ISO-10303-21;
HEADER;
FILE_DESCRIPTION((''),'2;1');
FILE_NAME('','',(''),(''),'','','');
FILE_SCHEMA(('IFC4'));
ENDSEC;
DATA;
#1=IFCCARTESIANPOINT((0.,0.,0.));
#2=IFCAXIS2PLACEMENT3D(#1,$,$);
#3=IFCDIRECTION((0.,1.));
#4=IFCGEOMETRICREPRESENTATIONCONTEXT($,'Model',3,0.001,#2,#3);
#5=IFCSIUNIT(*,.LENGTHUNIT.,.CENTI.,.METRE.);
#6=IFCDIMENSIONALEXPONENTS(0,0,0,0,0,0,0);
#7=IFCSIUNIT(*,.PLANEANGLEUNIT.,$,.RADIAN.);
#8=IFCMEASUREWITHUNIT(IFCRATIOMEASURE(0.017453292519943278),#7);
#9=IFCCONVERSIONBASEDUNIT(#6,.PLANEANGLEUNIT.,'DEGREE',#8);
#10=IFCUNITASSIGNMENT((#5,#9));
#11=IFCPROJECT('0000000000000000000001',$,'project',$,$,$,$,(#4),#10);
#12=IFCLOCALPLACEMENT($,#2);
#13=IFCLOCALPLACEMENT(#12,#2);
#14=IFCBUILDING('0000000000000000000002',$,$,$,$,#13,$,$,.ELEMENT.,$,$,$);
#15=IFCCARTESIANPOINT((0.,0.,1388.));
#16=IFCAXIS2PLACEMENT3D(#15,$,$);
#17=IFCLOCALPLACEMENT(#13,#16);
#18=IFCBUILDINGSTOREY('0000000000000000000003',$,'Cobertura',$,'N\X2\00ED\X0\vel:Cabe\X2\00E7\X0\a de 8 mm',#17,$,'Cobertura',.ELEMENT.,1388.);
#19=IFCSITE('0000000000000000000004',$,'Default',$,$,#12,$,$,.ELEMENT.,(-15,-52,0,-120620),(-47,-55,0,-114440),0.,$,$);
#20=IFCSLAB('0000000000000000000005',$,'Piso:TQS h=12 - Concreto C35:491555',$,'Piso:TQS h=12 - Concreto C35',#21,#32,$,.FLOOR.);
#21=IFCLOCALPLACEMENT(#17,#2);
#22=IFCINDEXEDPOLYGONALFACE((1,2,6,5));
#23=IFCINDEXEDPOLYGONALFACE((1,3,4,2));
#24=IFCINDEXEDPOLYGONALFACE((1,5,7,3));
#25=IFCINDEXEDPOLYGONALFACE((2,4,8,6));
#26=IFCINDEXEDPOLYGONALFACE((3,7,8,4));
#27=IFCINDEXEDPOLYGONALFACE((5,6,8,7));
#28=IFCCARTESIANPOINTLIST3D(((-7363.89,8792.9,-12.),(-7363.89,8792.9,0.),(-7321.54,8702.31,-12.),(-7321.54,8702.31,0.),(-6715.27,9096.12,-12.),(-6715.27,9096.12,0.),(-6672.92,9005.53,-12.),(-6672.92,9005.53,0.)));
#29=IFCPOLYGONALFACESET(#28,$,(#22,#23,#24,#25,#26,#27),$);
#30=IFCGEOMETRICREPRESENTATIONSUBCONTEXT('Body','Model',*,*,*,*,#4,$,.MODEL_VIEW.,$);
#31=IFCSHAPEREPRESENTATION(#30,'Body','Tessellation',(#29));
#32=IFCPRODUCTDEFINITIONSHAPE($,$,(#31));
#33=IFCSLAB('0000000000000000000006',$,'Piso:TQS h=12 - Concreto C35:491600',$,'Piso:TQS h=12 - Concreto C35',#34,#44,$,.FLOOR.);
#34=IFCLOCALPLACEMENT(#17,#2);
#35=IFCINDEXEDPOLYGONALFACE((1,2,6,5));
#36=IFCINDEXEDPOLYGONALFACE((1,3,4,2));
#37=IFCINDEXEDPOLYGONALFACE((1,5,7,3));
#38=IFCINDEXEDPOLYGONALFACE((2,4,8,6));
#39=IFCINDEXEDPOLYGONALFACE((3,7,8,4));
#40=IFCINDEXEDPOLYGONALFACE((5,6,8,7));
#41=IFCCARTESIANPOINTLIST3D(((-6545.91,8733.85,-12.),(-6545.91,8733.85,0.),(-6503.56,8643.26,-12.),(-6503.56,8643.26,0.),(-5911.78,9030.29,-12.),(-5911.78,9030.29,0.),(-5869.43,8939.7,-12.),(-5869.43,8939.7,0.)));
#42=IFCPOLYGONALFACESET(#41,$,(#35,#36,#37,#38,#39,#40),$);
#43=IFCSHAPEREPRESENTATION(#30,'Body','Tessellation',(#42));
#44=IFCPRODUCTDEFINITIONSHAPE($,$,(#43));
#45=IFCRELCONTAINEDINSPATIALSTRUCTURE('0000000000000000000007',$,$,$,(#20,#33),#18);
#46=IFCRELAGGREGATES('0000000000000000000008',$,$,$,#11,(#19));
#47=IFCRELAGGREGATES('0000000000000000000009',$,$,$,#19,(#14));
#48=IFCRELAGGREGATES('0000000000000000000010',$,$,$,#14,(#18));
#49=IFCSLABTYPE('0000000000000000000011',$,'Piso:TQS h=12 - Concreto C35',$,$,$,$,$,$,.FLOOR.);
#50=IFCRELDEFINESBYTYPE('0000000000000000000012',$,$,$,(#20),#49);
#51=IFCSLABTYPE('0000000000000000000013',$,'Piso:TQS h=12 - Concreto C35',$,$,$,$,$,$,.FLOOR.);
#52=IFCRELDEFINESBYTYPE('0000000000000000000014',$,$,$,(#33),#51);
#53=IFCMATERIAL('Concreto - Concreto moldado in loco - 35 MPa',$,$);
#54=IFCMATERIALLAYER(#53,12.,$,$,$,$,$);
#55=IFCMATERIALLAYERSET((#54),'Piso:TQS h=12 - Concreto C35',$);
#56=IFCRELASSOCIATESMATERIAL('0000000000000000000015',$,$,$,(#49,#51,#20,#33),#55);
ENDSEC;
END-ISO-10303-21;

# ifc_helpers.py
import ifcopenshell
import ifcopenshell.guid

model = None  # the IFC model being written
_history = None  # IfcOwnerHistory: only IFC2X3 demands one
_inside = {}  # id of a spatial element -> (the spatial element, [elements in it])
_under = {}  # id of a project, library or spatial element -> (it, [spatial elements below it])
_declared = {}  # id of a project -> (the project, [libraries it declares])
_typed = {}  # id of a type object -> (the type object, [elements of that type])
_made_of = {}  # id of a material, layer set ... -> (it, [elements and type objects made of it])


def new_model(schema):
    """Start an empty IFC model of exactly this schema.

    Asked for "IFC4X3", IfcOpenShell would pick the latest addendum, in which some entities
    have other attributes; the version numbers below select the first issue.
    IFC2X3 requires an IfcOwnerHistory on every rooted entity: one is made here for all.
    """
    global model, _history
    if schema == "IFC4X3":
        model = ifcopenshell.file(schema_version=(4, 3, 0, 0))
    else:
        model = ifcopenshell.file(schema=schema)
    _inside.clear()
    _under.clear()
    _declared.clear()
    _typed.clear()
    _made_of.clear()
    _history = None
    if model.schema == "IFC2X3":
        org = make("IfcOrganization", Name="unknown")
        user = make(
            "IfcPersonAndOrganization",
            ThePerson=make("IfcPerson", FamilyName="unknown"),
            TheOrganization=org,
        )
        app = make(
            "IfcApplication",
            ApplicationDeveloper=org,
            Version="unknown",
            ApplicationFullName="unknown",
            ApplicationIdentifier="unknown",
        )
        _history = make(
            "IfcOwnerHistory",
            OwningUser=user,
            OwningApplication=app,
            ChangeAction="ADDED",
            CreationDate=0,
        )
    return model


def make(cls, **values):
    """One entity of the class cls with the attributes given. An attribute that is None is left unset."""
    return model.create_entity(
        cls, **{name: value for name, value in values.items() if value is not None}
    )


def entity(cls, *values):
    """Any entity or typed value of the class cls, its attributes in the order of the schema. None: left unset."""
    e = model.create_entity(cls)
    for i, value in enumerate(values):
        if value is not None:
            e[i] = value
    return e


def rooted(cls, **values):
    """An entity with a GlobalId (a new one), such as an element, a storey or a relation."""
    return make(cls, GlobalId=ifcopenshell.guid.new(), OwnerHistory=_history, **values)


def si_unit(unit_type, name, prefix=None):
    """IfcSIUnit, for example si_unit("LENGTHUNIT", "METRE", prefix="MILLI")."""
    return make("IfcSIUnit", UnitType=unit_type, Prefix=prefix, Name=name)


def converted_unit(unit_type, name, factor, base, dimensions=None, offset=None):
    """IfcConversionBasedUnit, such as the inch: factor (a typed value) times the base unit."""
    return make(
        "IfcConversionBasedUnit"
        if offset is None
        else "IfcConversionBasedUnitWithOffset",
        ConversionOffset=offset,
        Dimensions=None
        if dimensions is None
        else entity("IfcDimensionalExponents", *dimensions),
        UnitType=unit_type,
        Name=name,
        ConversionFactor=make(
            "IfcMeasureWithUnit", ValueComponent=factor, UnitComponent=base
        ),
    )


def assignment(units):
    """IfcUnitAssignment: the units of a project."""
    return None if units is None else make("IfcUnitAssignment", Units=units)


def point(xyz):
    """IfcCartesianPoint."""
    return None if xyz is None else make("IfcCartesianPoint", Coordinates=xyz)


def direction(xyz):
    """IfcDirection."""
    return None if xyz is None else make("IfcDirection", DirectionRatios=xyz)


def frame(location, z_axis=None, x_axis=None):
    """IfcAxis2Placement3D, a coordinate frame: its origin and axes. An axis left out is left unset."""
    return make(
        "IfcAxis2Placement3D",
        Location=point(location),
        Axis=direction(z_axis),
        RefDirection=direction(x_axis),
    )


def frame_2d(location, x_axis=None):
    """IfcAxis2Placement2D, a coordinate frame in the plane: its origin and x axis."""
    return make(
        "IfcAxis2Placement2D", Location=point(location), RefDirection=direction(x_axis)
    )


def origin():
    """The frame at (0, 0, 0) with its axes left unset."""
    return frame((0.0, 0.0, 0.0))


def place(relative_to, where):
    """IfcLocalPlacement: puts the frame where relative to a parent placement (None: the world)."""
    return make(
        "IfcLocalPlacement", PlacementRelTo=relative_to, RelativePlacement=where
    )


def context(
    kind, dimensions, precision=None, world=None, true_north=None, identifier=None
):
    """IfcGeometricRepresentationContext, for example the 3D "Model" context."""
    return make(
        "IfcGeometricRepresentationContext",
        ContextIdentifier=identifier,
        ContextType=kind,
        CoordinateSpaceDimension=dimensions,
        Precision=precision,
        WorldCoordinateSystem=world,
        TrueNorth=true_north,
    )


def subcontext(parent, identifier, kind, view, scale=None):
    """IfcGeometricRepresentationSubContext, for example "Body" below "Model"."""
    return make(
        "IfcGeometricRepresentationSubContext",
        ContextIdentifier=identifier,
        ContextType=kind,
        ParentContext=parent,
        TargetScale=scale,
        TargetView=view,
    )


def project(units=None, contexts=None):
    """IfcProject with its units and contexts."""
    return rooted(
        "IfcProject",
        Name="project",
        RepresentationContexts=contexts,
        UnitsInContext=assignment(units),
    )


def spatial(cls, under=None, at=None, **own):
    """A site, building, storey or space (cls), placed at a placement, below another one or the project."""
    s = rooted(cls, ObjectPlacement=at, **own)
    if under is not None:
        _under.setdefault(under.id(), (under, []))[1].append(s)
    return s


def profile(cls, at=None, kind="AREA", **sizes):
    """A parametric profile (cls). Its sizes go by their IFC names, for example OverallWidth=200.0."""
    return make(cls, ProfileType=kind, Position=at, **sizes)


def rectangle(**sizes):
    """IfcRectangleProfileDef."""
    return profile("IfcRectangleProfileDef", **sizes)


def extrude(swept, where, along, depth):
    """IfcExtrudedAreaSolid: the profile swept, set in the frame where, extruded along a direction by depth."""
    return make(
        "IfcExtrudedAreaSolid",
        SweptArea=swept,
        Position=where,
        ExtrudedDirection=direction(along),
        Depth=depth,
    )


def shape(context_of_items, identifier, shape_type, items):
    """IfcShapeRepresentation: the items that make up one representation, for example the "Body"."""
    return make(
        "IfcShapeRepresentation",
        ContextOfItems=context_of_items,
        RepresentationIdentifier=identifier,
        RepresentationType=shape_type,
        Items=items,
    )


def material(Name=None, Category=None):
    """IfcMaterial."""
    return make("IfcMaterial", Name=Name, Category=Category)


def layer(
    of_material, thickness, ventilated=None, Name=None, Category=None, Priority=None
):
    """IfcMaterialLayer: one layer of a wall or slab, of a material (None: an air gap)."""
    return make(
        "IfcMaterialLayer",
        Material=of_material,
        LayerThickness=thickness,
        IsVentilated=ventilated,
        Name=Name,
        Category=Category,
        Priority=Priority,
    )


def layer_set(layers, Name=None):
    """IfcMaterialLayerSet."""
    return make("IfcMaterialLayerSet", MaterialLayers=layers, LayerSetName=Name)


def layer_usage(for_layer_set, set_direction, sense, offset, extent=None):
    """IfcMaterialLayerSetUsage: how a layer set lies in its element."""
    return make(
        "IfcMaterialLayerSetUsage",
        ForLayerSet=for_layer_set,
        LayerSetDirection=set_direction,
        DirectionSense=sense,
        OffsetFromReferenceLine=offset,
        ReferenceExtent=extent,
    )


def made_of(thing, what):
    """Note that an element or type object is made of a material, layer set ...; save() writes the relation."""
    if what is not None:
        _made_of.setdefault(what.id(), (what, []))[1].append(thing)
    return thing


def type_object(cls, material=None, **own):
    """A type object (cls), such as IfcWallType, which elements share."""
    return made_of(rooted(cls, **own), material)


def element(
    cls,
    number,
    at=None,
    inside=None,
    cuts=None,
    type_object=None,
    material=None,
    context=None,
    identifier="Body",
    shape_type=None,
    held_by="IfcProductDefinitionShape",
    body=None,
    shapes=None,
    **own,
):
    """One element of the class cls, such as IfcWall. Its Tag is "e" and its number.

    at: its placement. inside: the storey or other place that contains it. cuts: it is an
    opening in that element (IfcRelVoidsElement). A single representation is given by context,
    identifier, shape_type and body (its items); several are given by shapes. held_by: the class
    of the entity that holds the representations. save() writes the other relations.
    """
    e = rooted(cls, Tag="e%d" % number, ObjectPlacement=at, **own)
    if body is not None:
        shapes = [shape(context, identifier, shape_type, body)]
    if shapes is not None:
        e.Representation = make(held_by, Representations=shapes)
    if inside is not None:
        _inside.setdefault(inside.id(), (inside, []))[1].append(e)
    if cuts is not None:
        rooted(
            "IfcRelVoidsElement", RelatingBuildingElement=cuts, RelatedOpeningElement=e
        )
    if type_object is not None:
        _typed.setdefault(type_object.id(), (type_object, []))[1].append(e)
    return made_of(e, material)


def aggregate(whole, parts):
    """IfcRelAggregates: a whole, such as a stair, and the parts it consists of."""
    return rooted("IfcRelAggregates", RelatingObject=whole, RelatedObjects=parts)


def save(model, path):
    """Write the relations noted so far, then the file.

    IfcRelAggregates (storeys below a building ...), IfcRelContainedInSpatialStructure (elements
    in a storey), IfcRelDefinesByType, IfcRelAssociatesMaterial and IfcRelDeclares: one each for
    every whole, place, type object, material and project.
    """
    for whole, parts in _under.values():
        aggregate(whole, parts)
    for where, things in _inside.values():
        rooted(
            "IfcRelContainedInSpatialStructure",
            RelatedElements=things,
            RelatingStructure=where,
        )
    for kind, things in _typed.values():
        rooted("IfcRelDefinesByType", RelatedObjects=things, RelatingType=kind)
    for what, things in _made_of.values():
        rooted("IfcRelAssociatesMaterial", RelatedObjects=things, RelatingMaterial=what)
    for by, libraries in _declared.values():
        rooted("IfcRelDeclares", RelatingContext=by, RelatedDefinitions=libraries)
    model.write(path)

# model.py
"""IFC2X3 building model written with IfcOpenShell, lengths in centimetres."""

from ifc_helpers import new_model, entity, si_unit, converted_unit, direction, frame, frame_2d, origin, place, context, subcontext, project, spatial, rectangle, extrude, material, layer, layer_set, layer_usage, type_object, element, save


model = new_model("IFC2X3")

# Units and contexts
model_context = context("Model", 3, precision=0.001, world=origin(), true_north=direction((0.0, 1.0)))
body_context = subcontext(model_context, "Body", "Model", "MODEL_VIEW")
ifc_project = project(units=[si_unit("LENGTHUNIT", "METRE", prefix="CENTI"), converted_unit("PLANEANGLEUNIT", "DEGREE", entity("IfcRatioMeasure", 0.017453292519943278), si_unit("PLANEANGLEUNIT", "RADIAN"), dimensions=[0, 0, 0, 0, 0, 0, 0])], contexts=[model_context])

# Site, building, storey
site_placement = place(None, origin())
site = spatial("IfcSite", under=ifc_project, at=site_placement, Name="Default", CompositionType="ELEMENT", RefLatitude=(-15, -52, 0, -120620), RefLongitude=(-47, -55, 0, -114440), RefElevation=0.0)
building_placement = place(site_placement, origin())
building = spatial("IfcBuilding", under=site, at=building_placement, CompositionType="ELEMENT")
storey_placement = place(building_placement, frame((0.0, 0.0, 1388.0)))
storey = spatial("IfcBuildingStorey", under=building, at=storey_placement, Name="Cobertura", ObjectType="Nível:Cabeça de 8 mm", LongName="Cobertura", CompositionType="ELEMENT", Elevation=1388.0)

# Shared definitions
ifc_material = material(Name="Concreto - Concreto moldado in loco - 35 MPa")

# Slabs
ifc_layer_1 = layer(ifc_material, 12.0)
ifc_layer_set_1 = layer_set([ifc_layer_1], Name="Piso:TQS h=12 - Concreto C35")
ifc_layer_usage_1 = layer_usage(ifc_layer_set_1, "AXIS3", "POSITIVE", 0.0)
slab_type_1 = type_object("IfcSlabType", Name="Piso:TQS h=12 - Concreto C35", PredefinedType="FLOOR", material=ifc_layer_set_1)
slab_1_placement = place(storey_placement, origin())
element("IfcSlab", 1, at=slab_1_placement, inside=storey, type_object=slab_type_1, material=ifc_layer_usage_1, Name="Piso:TQS h=12 - Concreto C35:491555", ObjectType="Piso:TQS h=12 - Concreto C35", PredefinedType="FLOOR", context=body_context, shape_type="SweptSolid", body=[
    extrude(rectangle(XDim=100.0, YDim=716.0, at=frame_2d((0.0, 0.0), x_axis=(1.0, 0.0))), frame((-7018.4, 8899.21, 0.0), z_axis=(0.0, 0.0, -1.0), x_axis=(0.423488, -0.905902, 0.0)), (0.0, 0.0, 1.0), 12.0),
])
ifc_layer_usage_2 = layer_usage(ifc_layer_set_1, "AXIS3", "POSITIVE", 0.0)
slab_type_2 = type_object("IfcSlabType", Name="Piso:TQS h=12 - Concreto C35", PredefinedType="FLOOR", material=ifc_layer_set_1)
slab_2_placement = place(storey_placement, origin())
element("IfcSlab", 2, at=slab_2_placement, inside=storey, type_object=slab_type_2, material=ifc_layer_usage_2, Name="Piso:TQS h=12 - Concreto C35:491600", ObjectType="Piso:TQS h=12 - Concreto C35", PredefinedType="FLOOR", context=body_context, shape_type="SweptSolid", body=[
    extrude(rectangle(XDim=100.0, YDim=700.0, at=frame_2d((0.0, 0.0), x_axis=(1.0, 0.0))), frame((-6207.67, 8836.77, 0.0), z_axis=(0.0, 0.0, -1.0), x_axis=(0.423488, -0.905902, 0.0)), (0.0, 0.0, 1.0), 12.0),
])

save(model, "model.ifc")
